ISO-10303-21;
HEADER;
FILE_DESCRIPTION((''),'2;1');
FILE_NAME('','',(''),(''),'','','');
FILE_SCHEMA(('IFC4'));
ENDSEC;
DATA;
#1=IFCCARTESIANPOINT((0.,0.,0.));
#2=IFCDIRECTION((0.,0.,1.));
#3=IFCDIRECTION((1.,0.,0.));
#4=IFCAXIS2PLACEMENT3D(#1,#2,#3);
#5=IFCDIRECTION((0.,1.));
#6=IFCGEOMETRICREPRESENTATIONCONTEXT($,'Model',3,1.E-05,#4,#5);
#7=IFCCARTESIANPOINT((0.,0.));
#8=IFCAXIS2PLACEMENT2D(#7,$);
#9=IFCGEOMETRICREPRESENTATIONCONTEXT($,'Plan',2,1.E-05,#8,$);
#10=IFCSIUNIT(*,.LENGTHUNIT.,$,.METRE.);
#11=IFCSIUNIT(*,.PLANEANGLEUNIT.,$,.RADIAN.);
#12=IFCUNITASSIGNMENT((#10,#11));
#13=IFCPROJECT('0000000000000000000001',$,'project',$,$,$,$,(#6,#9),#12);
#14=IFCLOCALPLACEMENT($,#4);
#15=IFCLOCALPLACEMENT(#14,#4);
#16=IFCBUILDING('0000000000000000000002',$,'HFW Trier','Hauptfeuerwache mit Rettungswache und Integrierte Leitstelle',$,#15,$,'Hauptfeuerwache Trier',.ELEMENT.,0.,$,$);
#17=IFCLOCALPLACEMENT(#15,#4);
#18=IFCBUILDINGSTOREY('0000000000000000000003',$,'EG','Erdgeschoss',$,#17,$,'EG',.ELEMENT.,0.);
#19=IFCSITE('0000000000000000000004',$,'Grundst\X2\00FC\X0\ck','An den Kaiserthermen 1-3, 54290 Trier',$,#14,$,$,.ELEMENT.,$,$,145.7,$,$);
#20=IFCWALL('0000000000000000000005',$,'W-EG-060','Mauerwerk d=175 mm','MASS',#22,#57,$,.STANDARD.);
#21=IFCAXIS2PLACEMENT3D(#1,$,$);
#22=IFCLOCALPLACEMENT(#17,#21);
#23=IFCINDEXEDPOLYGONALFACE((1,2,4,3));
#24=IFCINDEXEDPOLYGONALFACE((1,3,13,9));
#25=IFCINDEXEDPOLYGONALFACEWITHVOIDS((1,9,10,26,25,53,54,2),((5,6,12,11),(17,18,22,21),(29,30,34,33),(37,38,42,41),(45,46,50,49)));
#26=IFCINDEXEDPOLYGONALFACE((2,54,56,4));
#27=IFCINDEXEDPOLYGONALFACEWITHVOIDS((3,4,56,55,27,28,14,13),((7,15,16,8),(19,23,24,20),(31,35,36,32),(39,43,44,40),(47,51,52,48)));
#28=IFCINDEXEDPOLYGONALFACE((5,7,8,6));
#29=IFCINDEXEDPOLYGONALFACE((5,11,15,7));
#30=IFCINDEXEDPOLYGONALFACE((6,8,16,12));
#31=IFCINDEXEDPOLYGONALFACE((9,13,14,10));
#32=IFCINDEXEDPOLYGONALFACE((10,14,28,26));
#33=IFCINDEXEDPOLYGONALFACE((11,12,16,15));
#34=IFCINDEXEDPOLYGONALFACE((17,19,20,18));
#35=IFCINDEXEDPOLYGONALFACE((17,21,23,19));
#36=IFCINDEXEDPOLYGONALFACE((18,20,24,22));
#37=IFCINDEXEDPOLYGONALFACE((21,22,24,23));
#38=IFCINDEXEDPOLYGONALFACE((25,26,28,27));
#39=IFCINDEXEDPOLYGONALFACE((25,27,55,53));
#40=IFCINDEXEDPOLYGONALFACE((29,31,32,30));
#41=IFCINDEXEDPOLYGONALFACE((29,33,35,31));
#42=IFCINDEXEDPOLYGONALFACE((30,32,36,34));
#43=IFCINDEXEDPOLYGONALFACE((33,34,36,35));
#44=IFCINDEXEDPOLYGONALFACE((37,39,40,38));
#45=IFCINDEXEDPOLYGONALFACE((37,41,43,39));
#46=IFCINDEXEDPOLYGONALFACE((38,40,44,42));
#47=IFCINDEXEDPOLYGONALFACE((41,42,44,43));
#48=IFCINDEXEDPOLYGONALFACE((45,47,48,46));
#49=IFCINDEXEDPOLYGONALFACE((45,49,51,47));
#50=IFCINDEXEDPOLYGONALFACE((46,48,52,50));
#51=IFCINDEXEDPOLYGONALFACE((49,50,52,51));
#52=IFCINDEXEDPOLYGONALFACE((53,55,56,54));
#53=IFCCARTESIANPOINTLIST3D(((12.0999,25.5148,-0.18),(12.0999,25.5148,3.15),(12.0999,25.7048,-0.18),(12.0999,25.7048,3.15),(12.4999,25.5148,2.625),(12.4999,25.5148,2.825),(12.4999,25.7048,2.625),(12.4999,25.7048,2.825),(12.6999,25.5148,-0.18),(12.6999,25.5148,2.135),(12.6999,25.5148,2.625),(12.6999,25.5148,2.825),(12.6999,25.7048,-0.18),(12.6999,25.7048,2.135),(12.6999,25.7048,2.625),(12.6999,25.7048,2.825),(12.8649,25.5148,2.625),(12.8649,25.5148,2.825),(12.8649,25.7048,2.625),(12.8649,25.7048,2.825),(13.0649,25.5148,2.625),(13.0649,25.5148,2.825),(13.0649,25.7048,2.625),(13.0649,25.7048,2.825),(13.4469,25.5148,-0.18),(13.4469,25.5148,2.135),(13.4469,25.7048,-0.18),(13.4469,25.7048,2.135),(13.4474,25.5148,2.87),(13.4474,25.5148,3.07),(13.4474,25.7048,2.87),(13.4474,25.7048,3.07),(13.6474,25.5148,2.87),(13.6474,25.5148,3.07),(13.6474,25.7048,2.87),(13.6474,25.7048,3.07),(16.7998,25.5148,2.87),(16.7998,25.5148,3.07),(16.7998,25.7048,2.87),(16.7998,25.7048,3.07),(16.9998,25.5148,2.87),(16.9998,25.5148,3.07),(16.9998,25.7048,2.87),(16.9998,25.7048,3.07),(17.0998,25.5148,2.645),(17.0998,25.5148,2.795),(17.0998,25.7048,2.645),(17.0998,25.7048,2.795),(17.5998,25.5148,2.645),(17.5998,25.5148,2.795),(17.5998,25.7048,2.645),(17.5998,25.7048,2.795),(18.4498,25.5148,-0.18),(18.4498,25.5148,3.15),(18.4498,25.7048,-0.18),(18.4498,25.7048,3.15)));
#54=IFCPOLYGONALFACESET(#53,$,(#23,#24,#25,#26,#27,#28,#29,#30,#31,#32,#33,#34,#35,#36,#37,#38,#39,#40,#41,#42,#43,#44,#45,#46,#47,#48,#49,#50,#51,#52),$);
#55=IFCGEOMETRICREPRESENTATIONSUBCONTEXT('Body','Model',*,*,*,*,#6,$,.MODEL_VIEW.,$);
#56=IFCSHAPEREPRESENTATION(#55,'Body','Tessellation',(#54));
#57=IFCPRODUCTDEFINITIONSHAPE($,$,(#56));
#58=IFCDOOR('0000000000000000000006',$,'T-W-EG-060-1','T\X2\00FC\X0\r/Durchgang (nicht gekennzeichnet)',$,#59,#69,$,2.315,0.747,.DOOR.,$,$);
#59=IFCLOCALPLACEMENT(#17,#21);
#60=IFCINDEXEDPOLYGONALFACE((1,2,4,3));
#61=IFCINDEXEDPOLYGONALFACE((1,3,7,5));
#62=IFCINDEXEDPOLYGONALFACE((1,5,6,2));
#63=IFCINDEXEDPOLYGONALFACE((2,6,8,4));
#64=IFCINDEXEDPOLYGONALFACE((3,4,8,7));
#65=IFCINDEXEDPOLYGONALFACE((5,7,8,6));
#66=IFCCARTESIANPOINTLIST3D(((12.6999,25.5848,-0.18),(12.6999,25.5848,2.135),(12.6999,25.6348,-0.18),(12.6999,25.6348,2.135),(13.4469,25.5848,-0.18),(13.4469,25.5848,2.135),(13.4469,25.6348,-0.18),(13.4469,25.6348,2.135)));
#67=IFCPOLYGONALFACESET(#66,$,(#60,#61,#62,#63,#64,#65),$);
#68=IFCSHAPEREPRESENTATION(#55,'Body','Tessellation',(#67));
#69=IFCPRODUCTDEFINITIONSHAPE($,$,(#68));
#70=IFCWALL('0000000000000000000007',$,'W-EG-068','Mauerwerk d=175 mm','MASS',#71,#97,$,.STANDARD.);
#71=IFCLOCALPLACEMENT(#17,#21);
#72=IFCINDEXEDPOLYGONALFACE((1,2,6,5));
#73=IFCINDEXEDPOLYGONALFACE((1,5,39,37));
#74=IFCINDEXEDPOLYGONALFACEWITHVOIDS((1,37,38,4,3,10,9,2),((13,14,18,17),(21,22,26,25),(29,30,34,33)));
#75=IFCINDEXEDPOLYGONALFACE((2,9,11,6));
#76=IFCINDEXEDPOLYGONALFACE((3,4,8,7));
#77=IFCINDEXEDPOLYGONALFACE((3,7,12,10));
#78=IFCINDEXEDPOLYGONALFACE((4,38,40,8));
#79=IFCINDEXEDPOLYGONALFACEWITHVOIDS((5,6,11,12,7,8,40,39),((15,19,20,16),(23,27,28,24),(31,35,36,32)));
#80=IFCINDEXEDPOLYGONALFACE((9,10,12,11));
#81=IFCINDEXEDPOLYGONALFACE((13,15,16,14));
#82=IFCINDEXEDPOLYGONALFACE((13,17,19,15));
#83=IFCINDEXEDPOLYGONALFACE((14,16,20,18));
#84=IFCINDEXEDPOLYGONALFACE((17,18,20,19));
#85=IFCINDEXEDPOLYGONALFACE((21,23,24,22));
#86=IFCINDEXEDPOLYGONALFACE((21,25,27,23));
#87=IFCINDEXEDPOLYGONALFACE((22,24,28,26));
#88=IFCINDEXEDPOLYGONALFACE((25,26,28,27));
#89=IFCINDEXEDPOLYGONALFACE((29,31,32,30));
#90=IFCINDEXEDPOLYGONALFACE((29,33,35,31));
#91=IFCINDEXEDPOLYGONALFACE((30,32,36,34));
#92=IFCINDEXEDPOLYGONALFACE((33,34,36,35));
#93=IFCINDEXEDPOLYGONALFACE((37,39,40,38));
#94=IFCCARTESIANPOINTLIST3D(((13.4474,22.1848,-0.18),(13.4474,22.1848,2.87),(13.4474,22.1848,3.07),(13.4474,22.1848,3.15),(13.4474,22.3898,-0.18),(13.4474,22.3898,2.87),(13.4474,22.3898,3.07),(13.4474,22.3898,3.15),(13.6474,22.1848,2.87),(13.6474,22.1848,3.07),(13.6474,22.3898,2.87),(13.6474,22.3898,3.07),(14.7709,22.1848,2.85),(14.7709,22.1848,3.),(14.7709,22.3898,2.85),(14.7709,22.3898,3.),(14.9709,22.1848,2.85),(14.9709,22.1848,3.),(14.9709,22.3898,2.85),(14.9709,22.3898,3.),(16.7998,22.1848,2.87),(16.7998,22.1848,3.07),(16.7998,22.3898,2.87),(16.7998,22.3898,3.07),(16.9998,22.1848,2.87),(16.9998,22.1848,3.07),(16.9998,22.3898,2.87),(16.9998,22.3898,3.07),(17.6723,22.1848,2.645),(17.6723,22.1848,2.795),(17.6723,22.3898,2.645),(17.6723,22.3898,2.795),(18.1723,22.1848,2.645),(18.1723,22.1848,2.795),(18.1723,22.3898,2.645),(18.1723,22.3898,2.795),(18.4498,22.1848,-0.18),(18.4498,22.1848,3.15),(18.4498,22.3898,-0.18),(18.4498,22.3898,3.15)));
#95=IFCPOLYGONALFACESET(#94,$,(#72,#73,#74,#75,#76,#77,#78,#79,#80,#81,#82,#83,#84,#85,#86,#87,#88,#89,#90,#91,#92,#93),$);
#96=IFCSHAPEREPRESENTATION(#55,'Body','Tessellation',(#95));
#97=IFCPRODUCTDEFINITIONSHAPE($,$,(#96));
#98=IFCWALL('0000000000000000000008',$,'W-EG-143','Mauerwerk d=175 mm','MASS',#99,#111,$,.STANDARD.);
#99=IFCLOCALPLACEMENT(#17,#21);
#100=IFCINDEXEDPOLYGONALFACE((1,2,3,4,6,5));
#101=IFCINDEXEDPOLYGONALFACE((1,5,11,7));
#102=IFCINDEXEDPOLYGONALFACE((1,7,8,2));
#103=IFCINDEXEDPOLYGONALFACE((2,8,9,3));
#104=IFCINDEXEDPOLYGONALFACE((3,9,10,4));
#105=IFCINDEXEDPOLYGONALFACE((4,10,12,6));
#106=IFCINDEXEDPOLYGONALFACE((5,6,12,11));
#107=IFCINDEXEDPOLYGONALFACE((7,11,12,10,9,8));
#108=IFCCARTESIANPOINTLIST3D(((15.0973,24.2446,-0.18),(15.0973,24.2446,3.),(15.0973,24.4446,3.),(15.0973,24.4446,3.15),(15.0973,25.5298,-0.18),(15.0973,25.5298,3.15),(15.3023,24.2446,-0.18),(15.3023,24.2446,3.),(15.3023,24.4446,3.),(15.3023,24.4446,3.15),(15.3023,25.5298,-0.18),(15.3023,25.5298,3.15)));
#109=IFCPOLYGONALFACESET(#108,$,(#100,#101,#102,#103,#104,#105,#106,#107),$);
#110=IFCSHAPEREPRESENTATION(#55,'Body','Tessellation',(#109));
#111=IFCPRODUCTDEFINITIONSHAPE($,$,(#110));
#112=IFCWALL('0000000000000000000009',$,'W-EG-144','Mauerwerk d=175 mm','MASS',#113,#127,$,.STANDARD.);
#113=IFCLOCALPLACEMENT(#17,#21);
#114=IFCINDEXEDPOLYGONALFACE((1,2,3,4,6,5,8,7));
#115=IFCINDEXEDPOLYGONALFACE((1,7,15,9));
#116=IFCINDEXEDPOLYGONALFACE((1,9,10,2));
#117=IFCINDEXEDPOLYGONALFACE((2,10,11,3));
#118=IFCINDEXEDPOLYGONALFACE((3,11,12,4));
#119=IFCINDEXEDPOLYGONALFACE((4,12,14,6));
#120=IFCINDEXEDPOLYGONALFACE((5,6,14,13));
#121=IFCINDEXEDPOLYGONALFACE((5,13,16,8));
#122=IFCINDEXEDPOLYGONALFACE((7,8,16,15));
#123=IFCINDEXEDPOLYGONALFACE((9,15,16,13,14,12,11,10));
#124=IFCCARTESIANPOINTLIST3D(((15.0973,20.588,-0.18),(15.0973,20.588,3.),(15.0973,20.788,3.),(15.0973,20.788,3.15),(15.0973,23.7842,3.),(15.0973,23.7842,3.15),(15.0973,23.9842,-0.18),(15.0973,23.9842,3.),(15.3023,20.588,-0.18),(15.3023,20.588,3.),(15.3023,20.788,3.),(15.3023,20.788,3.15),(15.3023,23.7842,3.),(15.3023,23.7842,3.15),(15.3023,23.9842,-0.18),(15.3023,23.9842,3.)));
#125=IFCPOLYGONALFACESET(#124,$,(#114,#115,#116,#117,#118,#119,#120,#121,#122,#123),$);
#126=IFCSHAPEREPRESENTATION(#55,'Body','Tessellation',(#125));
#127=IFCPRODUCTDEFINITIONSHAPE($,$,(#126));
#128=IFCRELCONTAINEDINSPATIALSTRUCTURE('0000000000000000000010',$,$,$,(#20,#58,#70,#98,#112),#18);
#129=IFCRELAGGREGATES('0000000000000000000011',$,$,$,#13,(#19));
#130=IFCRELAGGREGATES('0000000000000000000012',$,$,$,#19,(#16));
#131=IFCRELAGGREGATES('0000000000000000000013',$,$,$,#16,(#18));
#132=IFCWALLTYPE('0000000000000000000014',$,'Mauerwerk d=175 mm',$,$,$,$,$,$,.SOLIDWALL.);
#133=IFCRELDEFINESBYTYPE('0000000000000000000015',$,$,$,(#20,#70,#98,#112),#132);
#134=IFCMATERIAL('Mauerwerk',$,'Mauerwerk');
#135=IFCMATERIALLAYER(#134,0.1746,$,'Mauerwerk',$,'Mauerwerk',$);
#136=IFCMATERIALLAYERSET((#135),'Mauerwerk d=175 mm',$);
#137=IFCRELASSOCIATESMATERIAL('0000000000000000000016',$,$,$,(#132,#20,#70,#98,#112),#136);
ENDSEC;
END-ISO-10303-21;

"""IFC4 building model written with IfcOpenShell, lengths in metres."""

from ifc_helpers import new_model, si_unit, direction, frame, frame_2d, origin_with_axes, origin_2d, place, context, subcontext, project, spatial, rectangle, extrude, material, layer, layer_set, layer_usage, type_object, element, fill, save


model = new_model("IFC4")

# Units and contexts
model_context = context("Model", 3, precision=1e-05, world=origin_with_axes(), true_north=direction((0.0, 1.0)))
plan_context = context("Plan", 2, precision=1e-05, world=origin_2d())
body_context = subcontext(model_context, "Body", "Model", "MODEL_VIEW")
ifc_project = project(units=[si_unit("LENGTHUNIT", "METRE"), si_unit("PLANEANGLEUNIT", "RADIAN")], contexts=[model_context, plan_context])

# Site, building, storey
site_placement = place(None, origin_with_axes())
site = spatial("IfcSite", under=ifc_project, at=site_placement, Name="Grundstück", Description="An den Kaiserthermen 1-3, 54290 Trier", CompositionType="ELEMENT", RefElevation=145.7)
building_placement = place(site_placement, origin_with_axes())
building = spatial("IfcBuilding", under=site, at=building_placement, Name="HFW Trier", Description="Hauptfeuerwache mit Rettungswache und Integrierte Leitstelle", LongName="Hauptfeuerwache Trier", CompositionType="ELEMENT", ElevationOfRefHeight=0.0)
storey_placement = place(building_placement, origin_with_axes())
storey = spatial("IfcBuildingStorey", under=building, at=storey_placement, Name="EG", Description="Erdgeschoss", LongName="EG", CompositionType="ELEMENT", Elevation=0.0)

# Shared definitions
ifc_material_1 = material(Name="Mauerwerk", Category="Mauerwerk")
ifc_layer_1 = layer(ifc_material_1, 0.1746, Name="Mauerwerk", Category="Mauerwerk")
ifc_layer_set_1 = layer_set([ifc_layer_1], Name="Mauerwerk d=175 mm")
wall_type_1 = type_object("IfcWallType", Name="Mauerwerk d=175 mm", PredefinedType="SOLIDWALL", material=ifc_layer_set_1)

# Wall, openings, door
ifc_layer_usage_1 = layer_usage(ifc_layer_set_1, "AXIS2", "POSITIVE", -0.095)
wall_1_placement = place(storey_placement, frame((12.0999, 25.6098, -0.18), z_axis=(0.0, 0.0, 1.0), x_axis=(1.0, 0.0, 0.0)))
wall_1 = element("IfcWall", 1, at=wall_1_placement, inside=storey, type_object=wall_type_1, material=ifc_layer_usage_1, Name="W-EG-060", Description="Mauerwerk d=175 mm", ObjectType="MASS", PredefinedType="STANDARD", context=body_context, shape_type="SweptSolid", body=[
    extrude(rectangle(XDim=6.3499, YDim=0.19, at=frame_2d((3.1749, 0.0))), origin_with_axes(), (0.0, 0.0, 1.0), 3.33),
])
opening_1_placement = place(wall_1_placement, frame((0.6, 0.0, 0.0), z_axis=(0.0, 0.0, 1.0), x_axis=(1.0, 0.0, 0.0)))
opening_1 = element("IfcOpeningElement", 2, at=opening_1_placement, cuts=wall_1, PredefinedType="OPENING", context=body_context, shape_type="SweptSolid", body=[
    extrude(rectangle(XDim=0.747, YDim=0.29, at=frame_2d((0.3735, 0.0))), origin_with_axes(), (0.0, 0.0, 1.0), 2.315),
])
opening_2_placement = place(wall_1_placement, origin_with_axes())
element("IfcOpeningElement", 3, at=opening_2_placement, cuts=wall_1, ObjectType="Wanddurchbruch", PredefinedType="OPENING", context=body_context, shape_type="SweptSolid", body=[
    extrude(rectangle(XDim=0.2, YDim=0.29, at=frame_2d((0.5, 0.0))), frame((0.0, 0.0, 2.805), z_axis=(0.0, 0.0, 1.0), x_axis=(1.0, 0.0, 0.0)), (0.0, 0.0, 1.0), 0.2),
])
opening_3_placement = place(wall_1_placement, origin_with_axes())
element("IfcOpeningElement", 4, at=opening_3_placement, cuts=wall_1, ObjectType="Wanddurchbruch", PredefinedType="OPENING", context=body_context, shape_type="SweptSolid", body=[
    extrude(rectangle(XDim=0.2, YDim=0.29, at=frame_2d((0.865, 0.0))), frame((0.0, 0.0, 2.805), z_axis=(0.0, 0.0, 1.0), x_axis=(1.0, 0.0, 0.0)), (0.0, 0.0, 1.0), 0.2),
])
opening_4_placement = place(wall_1_placement, origin_with_axes())
element("IfcOpeningElement", 5, at=opening_4_placement, cuts=wall_1, ObjectType="Wanddurchbruch", PredefinedType="OPENING", context=body_context, shape_type="SweptSolid", body=[
    extrude(rectangle(XDim=0.2, YDim=0.29, at=frame_2d((1.4475, 0.0))), frame((0.0, 0.0, 3.05), z_axis=(0.0, 0.0, 1.0), x_axis=(1.0, 0.0, 0.0)), (0.0, 0.0, 1.0), 0.2),
])
opening_5_placement = place(wall_1_placement, origin_with_axes())
element("IfcOpeningElement", 6, at=opening_5_placement, cuts=wall_1, ObjectType="Wanddurchbruch", PredefinedType="OPENING", context=body_context, shape_type="SweptSolid", body=[
    extrude(rectangle(XDim=0.2, YDim=0.29, at=frame_2d((4.7999, 0.0))), frame((0.0, 0.0, 3.05), z_axis=(0.0, 0.0, 1.0), x_axis=(1.0, 0.0, 0.0)), (0.0, 0.0, 1.0), 0.2),
])
opening_6_placement = place(wall_1_placement, origin_with_axes())
element("IfcOpeningElement", 7, at=opening_6_placement, cuts=wall_1, ObjectType="Wanddurchbruch", PredefinedType="OPENING", context=body_context, shape_type="SweptSolid", body=[
    extrude(rectangle(XDim=0.5, YDim=0.29, at=frame_2d((5.2499, 0.0))), frame((0.0, 0.0, 2.825), z_axis=(0.0, 0.0, 1.0), x_axis=(1.0, 0.0, 0.0)), (0.0, 0.0, 1.0), 0.15),
])
door_1_placement = place(wall_1_placement, frame((0.6, 0.0, 0.0), z_axis=(0.0, 0.0, 1.0), x_axis=(1.0, 0.0, 0.0)))
door_1 = element("IfcDoor", 8, at=door_1_placement, inside=storey, Name="T-W-EG-060-1", Description="Tür/Durchgang (nicht gekennzeichnet)", OverallHeight=2.315, OverallWidth=0.747, PredefinedType="DOOR", context=body_context, shape_type="SweptSolid", body=[
    extrude(rectangle(XDim=0.747, YDim=0.05, at=frame_2d((0.3735, 0.0))), origin_with_axes(), (0.0, 0.0, 1.0), 2.315),
])
fill(opening_1, door_1)

# Wall, openings
ifc_layer_usage_2 = layer_usage(ifc_layer_set_1, "AXIS2", "POSITIVE", -0.1025)
wall_2_placement = place(storey_placement, frame((13.4474, 22.2873, -0.18), z_axis=(0.0, 0.0, 1.0), x_axis=(1.0, 0.0, 0.0)))
wall_2 = element("IfcWall", 9, at=wall_2_placement, inside=storey, type_object=wall_type_1, material=ifc_layer_usage_2, Name="W-EG-068", Description="Mauerwerk d=175 mm", ObjectType="MASS", PredefinedType="STANDARD", context=body_context, shape_type="SweptSolid", body=[
    extrude(rectangle(XDim=5.0024, YDim=0.205, at=frame_2d((2.5012, 0.0))), origin_with_axes(), (0.0, 0.0, 1.0), 3.33),
])
opening_7_placement = place(wall_2_placement, origin_with_axes())
element("IfcOpeningElement", 10, at=opening_7_placement, cuts=wall_2, ObjectType="Wanddurchbruch", PredefinedType="OPENING", context=body_context, shape_type="SweptSolid", body=[
    extrude(rectangle(XDim=0.2, YDim=0.305, at=frame_2d((0.1, 0.0))), frame((0.0, 0.0, 3.05), z_axis=(0.0, 0.0, 1.0), x_axis=(1.0, 0.0, 0.0)), (0.0, 0.0, 1.0), 0.2),
])
opening_8_placement = place(wall_2_placement, origin_with_axes())
element("IfcOpeningElement", 11, at=opening_8_placement, cuts=wall_2, ObjectType="Wanddurchbruch", PredefinedType="OPENING", context=body_context, shape_type="SweptSolid", body=[
    extrude(rectangle(XDim=0.2, YDim=0.305, at=frame_2d((1.4235, 0.0))), frame((0.0, 0.0, 3.03), z_axis=(0.0, 0.0, 1.0), x_axis=(1.0, 0.0, 0.0)), (0.0, 0.0, 1.0), 0.15),
])
opening_9_placement = place(wall_2_placement, origin_with_axes())
element("IfcOpeningElement", 12, at=opening_9_placement, cuts=wall_2, ObjectType="Wanddurchbruch", PredefinedType="OPENING", context=body_context, shape_type="SweptSolid", body=[
    extrude(rectangle(XDim=0.2, YDim=0.305, at=frame_2d((3.4524, 0.0))), frame((0.0, 0.0, 3.05), z_axis=(0.0, 0.0, 1.0), x_axis=(1.0, 0.0, 0.0)), (0.0, 0.0, 1.0), 0.2),
])
opening_10_placement = place(wall_2_placement, origin_with_axes())
element("IfcOpeningElement", 13, at=opening_10_placement, cuts=wall_2, ObjectType="Wanddurchbruch", PredefinedType="OPENING", context=body_context, shape_type="SweptSolid", body=[
    extrude(rectangle(XDim=0.5, YDim=0.305, at=frame_2d((4.4749, 0.0))), frame((0.0, 0.0, 2.825), z_axis=(0.0, 0.0, 1.0), x_axis=(1.0, 0.0, 0.0)), (0.0, 0.0, 1.0), 0.15),
])

# Wall, opening
ifc_layer_usage_3 = layer_usage(ifc_layer_set_1, "AXIS2", "POSITIVE", -0.1025)
wall_3_placement = place(storey_placement, frame((15.1998, 25.5298, -0.18), z_axis=(0.0, 0.0, 1.0), x_axis=(0.0, -1.0, 0.0)))
wall_3 = element("IfcWall", 14, at=wall_3_placement, inside=storey, type_object=wall_type_1, material=ifc_layer_usage_3, Name="W-EG-143", Description="Mauerwerk d=175 mm", ObjectType="MASS", PredefinedType="STANDARD", context=body_context, shape_type="SweptSolid", body=[
    extrude(rectangle(XDim=1.2852, YDim=0.205, at=frame_2d((0.6426, 0.0))), origin_with_axes(), (0.0, 0.0, 1.0), 3.33),
])
opening_11_placement = place(wall_3_placement, origin_with_axes())
element("IfcOpeningElement", 15, at=opening_11_placement, cuts=wall_3, ObjectType="Wanddurchbruch", PredefinedType="OPENING", context=body_context, shape_type="SweptSolid", body=[
    extrude(rectangle(XDim=0.2, YDim=0.305, at=frame_2d((1.1852, 0.0))), frame((0.0, 0.0, 3.18), z_axis=(0.0, 0.0, 1.0), x_axis=(1.0, 0.0, 0.0)), (0.0, 0.0, 1.0), 0.15),
])

# Wall, openings
ifc_layer_usage_4 = layer_usage(ifc_layer_set_1, "AXIS2", "POSITIVE", -0.1025)
wall_4_placement = place(storey_placement, frame((15.1998, 23.9842, -0.18), z_axis=(0.0, 0.0, 1.0), x_axis=(0.0, -1.0, 0.0)))
wall_4 = element("IfcWall", 16, at=wall_4_placement, inside=storey, type_object=wall_type_1, material=ifc_layer_usage_4, Name="W-EG-144", Description="Mauerwerk d=175 mm", ObjectType="MASS", PredefinedType="STANDARD", context=body_context, shape_type="SweptSolid", body=[
    extrude(rectangle(XDim=3.3962, YDim=0.205, at=frame_2d((1.6981, 0.0))), origin_with_axes(), (0.0, 0.0, 1.0), 3.33),
])
opening_12_placement = place(wall_4_placement, origin_with_axes())
element("IfcOpeningElement", 17, at=opening_12_placement, cuts=wall_4, ObjectType="Wanddurchbruch", PredefinedType="OPENING", context=body_context, shape_type="SweptSolid", body=[
    extrude(rectangle(XDim=0.2, YDim=0.305, at=frame_2d((0.1, 0.0))), frame((0.0, 0.0, 3.18), z_axis=(0.0, 0.0, 1.0), x_axis=(1.0, 0.0, 0.0)), (0.0, 0.0, 1.0), 0.15),
])
opening_13_placement = place(wall_4_placement, origin_with_axes())
element("IfcOpeningElement", 18, at=opening_13_placement, cuts=wall_4, ObjectType="Wanddurchbruch", PredefinedType="OPENING", context=body_context, shape_type="SweptSolid", body=[
    extrude(rectangle(XDim=0.2, YDim=0.305, at=frame_2d((3.2962, 0.0))), frame((0.0, 0.0, 3.18), z_axis=(0.0, 0.0, 1.0), x_axis=(1.0, 0.0, 0.0)), (0.0, 0.0, 1.0), 0.15),
])

save(model, "model.ifc")
